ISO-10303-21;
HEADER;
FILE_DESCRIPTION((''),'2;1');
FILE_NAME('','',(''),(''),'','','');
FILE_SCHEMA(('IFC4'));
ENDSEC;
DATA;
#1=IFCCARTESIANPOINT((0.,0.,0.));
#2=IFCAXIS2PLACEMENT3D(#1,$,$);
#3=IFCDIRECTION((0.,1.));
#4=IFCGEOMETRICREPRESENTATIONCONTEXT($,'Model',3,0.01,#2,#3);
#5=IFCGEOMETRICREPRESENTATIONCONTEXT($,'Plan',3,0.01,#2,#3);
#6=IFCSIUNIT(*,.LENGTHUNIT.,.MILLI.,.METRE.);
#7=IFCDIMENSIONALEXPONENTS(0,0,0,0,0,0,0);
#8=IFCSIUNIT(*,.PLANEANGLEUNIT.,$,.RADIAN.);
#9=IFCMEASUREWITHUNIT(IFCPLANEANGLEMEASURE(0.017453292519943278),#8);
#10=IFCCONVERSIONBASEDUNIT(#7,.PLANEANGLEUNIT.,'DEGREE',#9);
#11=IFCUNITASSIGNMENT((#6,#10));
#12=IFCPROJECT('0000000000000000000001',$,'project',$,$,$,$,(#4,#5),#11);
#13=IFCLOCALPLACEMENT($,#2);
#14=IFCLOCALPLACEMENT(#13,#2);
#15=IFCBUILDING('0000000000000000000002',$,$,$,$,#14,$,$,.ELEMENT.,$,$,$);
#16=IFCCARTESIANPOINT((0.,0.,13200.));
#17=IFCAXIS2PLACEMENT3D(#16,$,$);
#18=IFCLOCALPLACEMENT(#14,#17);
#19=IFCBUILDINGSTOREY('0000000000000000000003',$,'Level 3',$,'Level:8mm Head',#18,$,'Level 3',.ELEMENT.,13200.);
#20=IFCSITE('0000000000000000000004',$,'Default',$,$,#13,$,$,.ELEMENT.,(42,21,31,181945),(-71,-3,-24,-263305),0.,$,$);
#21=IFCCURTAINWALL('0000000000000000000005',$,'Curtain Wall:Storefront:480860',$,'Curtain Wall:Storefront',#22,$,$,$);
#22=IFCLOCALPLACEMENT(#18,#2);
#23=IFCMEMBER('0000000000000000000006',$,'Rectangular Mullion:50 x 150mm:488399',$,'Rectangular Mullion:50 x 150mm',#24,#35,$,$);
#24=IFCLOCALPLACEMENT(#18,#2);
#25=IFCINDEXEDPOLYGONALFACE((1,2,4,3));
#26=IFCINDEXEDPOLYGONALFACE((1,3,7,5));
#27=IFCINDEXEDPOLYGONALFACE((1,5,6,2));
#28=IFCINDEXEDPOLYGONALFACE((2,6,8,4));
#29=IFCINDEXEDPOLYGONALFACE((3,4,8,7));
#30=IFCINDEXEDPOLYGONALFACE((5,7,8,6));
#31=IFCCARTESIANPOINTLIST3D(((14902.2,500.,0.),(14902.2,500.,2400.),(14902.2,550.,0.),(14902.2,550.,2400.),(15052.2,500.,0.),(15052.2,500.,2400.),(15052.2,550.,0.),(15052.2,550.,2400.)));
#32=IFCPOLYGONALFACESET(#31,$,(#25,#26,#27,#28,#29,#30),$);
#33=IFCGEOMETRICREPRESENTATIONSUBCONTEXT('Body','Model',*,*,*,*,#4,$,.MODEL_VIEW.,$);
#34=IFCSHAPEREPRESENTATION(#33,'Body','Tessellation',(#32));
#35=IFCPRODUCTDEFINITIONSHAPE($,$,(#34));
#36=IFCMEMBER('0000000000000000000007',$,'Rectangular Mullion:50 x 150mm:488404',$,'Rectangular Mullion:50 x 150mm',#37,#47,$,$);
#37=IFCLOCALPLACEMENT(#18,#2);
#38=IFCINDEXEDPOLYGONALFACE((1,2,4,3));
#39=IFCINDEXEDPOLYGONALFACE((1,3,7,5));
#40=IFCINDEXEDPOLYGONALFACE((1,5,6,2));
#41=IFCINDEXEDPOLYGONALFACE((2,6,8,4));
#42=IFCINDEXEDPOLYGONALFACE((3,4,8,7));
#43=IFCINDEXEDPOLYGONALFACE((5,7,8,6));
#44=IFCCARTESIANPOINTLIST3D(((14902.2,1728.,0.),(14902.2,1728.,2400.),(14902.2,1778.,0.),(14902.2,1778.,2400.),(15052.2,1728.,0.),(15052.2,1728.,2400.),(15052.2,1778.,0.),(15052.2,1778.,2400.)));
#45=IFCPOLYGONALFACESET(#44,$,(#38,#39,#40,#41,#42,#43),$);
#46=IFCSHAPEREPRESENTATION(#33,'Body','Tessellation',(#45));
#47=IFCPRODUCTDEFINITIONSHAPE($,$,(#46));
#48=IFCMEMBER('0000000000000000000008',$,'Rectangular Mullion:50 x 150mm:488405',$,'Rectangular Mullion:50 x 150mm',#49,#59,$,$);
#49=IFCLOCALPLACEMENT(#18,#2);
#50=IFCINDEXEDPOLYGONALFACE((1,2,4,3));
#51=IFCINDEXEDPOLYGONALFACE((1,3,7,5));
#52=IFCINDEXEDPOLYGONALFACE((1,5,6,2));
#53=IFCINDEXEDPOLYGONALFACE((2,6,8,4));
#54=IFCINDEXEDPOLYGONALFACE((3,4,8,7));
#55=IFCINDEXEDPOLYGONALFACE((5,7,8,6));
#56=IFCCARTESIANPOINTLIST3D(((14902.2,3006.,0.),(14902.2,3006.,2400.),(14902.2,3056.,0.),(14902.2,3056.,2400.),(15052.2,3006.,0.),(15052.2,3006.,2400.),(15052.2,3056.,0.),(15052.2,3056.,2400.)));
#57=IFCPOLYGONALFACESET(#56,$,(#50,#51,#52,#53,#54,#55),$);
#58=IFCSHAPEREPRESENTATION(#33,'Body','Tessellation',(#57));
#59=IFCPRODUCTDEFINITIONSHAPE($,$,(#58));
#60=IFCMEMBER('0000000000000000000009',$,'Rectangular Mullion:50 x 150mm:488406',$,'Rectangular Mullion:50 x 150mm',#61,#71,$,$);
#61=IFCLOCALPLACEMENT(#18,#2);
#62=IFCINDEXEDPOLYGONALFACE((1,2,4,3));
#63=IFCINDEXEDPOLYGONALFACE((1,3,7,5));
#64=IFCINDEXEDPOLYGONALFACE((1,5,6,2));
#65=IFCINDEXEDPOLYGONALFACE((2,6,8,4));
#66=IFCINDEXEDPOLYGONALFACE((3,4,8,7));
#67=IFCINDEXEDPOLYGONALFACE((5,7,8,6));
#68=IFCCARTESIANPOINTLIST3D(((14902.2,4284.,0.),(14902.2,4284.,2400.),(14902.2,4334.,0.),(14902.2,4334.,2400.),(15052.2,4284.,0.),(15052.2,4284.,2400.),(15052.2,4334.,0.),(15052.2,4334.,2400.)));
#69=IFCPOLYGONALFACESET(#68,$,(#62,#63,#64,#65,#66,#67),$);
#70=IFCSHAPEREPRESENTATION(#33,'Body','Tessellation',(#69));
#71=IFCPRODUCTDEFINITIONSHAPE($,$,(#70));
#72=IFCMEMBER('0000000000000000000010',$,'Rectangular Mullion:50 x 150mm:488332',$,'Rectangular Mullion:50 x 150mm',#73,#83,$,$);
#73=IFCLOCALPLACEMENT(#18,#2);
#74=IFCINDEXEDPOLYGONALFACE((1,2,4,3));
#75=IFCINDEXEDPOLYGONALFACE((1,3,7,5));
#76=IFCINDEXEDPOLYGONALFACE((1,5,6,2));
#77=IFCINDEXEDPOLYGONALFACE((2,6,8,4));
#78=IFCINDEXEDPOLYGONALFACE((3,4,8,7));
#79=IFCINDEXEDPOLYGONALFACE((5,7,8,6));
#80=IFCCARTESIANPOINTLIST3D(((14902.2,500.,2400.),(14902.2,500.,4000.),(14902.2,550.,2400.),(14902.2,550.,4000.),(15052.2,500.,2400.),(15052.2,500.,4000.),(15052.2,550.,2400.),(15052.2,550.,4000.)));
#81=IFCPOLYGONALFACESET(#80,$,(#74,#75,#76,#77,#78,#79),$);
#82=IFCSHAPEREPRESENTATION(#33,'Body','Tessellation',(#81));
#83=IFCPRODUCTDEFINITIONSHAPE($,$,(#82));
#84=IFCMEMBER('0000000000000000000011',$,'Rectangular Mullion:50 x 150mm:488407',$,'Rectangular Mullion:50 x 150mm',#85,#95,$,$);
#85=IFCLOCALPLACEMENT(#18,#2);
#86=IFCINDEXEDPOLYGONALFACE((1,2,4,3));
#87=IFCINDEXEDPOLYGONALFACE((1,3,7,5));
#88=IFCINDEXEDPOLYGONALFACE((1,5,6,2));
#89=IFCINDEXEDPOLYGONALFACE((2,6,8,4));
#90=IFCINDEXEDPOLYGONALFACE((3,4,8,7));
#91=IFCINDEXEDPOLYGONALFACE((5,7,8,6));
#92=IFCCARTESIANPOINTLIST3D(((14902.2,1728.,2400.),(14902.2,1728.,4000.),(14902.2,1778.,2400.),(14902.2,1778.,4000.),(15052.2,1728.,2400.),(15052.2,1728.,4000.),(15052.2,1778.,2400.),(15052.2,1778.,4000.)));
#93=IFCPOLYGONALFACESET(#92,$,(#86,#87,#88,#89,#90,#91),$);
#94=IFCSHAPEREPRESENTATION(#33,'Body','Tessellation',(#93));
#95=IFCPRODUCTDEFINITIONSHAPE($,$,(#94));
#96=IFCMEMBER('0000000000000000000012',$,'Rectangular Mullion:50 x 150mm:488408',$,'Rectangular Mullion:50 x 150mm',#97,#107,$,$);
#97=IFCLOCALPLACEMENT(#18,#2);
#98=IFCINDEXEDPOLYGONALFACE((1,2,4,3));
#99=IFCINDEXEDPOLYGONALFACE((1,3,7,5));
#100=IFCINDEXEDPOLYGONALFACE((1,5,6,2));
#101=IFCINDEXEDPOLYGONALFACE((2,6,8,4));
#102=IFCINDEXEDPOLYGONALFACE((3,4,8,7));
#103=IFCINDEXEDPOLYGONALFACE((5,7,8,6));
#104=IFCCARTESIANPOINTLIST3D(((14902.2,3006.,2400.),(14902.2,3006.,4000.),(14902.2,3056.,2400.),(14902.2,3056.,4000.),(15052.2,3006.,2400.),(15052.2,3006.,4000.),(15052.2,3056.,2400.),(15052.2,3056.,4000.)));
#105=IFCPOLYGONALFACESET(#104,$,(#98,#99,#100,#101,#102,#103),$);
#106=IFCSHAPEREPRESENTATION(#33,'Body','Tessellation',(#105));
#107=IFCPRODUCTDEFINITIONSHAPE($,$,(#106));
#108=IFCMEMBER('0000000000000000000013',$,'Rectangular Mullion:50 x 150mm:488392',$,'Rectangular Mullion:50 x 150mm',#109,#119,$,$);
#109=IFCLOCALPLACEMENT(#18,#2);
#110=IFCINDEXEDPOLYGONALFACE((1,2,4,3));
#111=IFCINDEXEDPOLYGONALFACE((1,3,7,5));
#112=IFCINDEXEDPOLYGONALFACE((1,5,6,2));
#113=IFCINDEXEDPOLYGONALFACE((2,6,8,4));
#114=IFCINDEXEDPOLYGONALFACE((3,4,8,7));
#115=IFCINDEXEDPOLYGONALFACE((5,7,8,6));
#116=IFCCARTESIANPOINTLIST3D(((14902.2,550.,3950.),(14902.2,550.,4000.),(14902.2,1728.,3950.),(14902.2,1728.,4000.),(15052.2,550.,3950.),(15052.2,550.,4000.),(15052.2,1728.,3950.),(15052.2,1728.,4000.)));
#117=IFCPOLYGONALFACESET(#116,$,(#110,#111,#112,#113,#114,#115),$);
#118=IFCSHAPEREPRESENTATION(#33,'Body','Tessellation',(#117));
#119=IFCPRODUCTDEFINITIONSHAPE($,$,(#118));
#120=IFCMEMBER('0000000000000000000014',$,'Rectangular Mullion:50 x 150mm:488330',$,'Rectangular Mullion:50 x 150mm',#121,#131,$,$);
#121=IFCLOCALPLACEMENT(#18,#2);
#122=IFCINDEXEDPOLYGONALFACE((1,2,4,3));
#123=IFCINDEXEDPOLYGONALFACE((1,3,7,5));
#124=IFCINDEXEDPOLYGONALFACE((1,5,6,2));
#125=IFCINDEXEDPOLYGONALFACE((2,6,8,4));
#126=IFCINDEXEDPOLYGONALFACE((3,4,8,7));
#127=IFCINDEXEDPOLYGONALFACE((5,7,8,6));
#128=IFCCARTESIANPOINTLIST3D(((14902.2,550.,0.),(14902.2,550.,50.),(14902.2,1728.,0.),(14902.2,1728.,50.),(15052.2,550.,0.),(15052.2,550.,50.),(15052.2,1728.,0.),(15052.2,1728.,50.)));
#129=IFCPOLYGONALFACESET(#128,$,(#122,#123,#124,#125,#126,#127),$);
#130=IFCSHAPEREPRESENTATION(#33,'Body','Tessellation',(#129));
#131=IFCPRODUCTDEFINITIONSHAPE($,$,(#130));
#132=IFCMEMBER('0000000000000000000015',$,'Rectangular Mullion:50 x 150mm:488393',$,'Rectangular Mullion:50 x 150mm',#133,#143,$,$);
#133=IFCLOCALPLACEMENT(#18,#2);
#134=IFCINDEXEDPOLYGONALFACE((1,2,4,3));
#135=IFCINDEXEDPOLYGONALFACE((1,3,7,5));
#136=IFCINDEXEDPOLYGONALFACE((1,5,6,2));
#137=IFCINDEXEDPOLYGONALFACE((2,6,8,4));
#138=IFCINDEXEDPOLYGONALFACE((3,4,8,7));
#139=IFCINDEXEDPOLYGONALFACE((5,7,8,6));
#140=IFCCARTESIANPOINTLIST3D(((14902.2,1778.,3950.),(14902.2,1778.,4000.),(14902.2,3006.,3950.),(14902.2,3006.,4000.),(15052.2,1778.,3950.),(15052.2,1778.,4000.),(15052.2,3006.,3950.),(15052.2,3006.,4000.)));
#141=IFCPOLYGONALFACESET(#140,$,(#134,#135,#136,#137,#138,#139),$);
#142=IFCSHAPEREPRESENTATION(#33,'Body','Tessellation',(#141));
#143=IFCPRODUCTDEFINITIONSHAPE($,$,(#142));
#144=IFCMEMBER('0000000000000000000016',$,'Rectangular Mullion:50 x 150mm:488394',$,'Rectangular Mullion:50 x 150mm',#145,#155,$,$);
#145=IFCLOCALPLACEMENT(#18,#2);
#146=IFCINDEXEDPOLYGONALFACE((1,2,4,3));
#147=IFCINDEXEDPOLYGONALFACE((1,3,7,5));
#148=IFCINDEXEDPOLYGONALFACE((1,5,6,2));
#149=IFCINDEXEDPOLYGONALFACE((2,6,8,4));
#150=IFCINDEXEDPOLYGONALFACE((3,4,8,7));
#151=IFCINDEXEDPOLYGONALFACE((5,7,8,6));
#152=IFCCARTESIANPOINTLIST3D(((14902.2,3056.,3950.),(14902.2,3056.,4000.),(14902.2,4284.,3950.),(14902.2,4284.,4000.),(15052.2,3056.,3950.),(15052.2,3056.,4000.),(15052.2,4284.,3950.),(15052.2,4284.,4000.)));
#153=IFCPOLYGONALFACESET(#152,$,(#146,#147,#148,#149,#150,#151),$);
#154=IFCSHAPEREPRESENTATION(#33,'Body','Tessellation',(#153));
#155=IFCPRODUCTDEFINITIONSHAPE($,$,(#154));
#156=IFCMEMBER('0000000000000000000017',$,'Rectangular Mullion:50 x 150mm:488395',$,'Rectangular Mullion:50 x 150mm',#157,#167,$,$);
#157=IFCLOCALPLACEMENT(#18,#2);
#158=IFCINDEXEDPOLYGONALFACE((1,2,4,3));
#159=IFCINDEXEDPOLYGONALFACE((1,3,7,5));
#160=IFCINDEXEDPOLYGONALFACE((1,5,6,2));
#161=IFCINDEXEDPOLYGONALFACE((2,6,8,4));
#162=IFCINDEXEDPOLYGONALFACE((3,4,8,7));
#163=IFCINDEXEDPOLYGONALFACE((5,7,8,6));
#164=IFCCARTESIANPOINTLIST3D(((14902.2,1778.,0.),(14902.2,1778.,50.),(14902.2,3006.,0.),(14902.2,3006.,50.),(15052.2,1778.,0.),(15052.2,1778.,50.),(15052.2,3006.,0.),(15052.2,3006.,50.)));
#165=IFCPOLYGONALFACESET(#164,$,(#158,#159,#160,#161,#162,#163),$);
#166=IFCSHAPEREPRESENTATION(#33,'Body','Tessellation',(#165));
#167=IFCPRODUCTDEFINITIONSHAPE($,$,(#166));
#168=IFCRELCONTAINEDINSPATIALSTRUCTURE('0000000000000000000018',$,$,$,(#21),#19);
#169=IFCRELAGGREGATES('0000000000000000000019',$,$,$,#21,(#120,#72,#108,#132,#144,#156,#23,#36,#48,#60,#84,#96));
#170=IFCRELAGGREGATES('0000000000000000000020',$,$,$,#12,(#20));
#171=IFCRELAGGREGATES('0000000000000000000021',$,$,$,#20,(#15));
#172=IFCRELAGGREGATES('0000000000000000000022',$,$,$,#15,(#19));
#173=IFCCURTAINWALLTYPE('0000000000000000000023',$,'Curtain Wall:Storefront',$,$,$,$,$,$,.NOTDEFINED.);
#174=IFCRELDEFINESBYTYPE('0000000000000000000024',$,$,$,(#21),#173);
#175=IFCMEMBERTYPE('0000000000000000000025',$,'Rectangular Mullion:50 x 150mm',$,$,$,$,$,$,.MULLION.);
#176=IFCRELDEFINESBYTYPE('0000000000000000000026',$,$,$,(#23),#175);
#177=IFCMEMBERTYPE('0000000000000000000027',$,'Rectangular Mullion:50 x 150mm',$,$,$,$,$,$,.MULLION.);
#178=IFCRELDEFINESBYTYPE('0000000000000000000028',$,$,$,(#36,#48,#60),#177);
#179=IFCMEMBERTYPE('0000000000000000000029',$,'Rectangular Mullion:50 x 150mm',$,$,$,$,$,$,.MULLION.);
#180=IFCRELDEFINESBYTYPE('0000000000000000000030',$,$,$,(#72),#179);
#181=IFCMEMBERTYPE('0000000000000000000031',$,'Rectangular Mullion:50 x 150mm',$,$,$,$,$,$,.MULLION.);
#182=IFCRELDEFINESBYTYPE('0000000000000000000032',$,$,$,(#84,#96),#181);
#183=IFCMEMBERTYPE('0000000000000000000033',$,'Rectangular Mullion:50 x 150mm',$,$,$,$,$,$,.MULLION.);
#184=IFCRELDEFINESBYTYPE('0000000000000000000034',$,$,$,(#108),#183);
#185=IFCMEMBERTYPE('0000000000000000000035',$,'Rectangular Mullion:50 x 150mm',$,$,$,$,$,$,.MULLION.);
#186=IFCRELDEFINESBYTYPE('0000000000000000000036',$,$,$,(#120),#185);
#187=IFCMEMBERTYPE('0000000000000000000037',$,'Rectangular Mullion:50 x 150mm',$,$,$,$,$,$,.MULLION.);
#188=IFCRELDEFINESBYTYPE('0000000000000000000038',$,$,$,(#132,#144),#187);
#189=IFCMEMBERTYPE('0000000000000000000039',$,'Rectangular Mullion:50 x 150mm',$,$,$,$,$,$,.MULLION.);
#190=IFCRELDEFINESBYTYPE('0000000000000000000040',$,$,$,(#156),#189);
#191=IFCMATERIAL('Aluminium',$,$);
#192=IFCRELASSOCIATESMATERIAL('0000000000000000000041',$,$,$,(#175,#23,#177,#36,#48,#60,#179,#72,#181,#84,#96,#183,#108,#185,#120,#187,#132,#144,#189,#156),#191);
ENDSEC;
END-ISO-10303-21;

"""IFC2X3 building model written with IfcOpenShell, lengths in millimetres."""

from ifc_helpers import new_model, entity, si_unit, converted_unit, direction, frame, origin, origin_2d_with_axis, place, context, subcontext, project, spatial, rectangle, extrude, source, transform, mapped, material, type_object, type_shapes, element, aggregate, save


model = new_model("IFC2X3")

# Units and contexts
model_context = context("Model", 3, precision=0.01, world=origin(), true_north=direction((0.0, 1.0)))
plan_context = context("Plan", 3, precision=0.01, world=origin(), true_north=direction((0.0, 1.0)))
body_context = subcontext(model_context, "Body", "Model", "MODEL_VIEW")
ifc_project = project(units=[si_unit("LENGTHUNIT", "METRE", prefix="MILLI"), converted_unit("PLANEANGLEUNIT", "DEGREE", entity("IfcPlaneAngleMeasure", 0.017453292519943278), si_unit("PLANEANGLEUNIT", "RADIAN"), dimensions=[0, 0, 0, 0, 0, 0, 0])], contexts=[model_context, plan_context])

# Site, building, storey
site_placement = place(None, origin())
site = spatial("IfcSite", under=ifc_project, at=site_placement, Name="Default", CompositionType="ELEMENT", RefLatitude=(42, 21, 31, 181945), RefLongitude=(-71, -3, -24, -263305), RefElevation=0.0)
building_placement = place(site_placement, origin())
building = spatial("IfcBuilding", under=site, at=building_placement, CompositionType="ELEMENT")
storey_placement = place(building_placement, frame((0.0, 0.0, 13200.0)))
storey = spatial("IfcBuildingStorey", under=building, at=storey_placement, Name="Level 3", ObjectType="Level:8mm Head", LongName="Level 3", CompositionType="ELEMENT", Elevation=13200.0)

# Curtain wall, members
curtain_wall_type = type_object("IfcCurtainWallType", Name="Curtain Wall:Storefront", PredefinedType="NOTDEFINED")
curtain_wall_placement = place(storey_placement, frame((0.0, 0.0, -13200.0)))
curtain_wall = element("IfcCurtainWall", 1, at=curtain_wall_placement, inside=storey, type_object=curtain_wall_type, Name="Curtain Wall:Storefront:480860", ObjectType="Curtain Wall:Storefront")
ifc_material_1 = material(Name="Aluminium")
member_type_1 = type_object("IfcMemberType", Name="Rectangular Mullion:50 x 150mm", PredefinedType="MULLION", material=ifc_material_1)
shared_shape_1 = source(origin(), body_context, "Body", "SweptSolid", [
    extrude(rectangle(XDim=50.0, YDim=150.0, at=origin_2d_with_axis()), frame((-25.0, 0.0, -2400.0), z_axis=(0.0, 0.0, 1.0), x_axis=(-1.0, 0.0, 0.0)), (0.0, 0.0, 1.0), 2400.0),
])
type_shapes(member_type_1, [shared_shape_1])
member_1_placement = place(curtain_wall_placement, frame((14977.2, 500.0, 15600.0), z_axis=(0.0, 0.0, 1.0), x_axis=(0.0, -1.0, 0.0)))
member_1 = element("IfcMember", 2, at=member_1_placement, type_object=member_type_1, material=ifc_material_1, Name="Rectangular Mullion:50 x 150mm:488399", ObjectType="Rectangular Mullion:50 x 150mm", context=body_context, shape_type="MappedRepresentation", body=[
    mapped(shared_shape_1, transform((0.0, 0.0, 0.0), scale=1.0)),
])
member_type_2 = type_object("IfcMemberType", Name="Rectangular Mullion:50 x 150mm", PredefinedType="MULLION", material=ifc_material_1)
shared_shape_2 = source(origin(), body_context, "Body", "SweptSolid", [
    extrude(rectangle(XDim=50.0, YDim=150.0, at=origin_2d_with_axis()), frame((0.0, 0.0, -2400.0), z_axis=(0.0, 0.0, 1.0), x_axis=(-1.0, 0.0, 0.0)), (0.0, 0.0, 1.0), 2400.0),
])
type_shapes(member_type_2, [shared_shape_2])
member_2_placement = place(curtain_wall_placement, frame((14977.2, 1753.0, 13200.0), z_axis=(0.0, 0.0, -1.0), x_axis=(0.0, 1.0, 0.0)))
member_2 = element("IfcMember", 3, at=member_2_placement, type_object=member_type_2, material=ifc_material_1, Name="Rectangular Mullion:50 x 150mm:488404", ObjectType="Rectangular Mullion:50 x 150mm", context=body_context, shape_type="MappedRepresentation", body=[
    mapped(shared_shape_2, transform((0.0, 0.0, 0.0), scale=1.0)),
])
member_3_placement = place(curtain_wall_placement, frame((14977.2, 3031.0, 13200.0), z_axis=(0.0, 0.0, -1.0), x_axis=(0.0, 1.0, 0.0)))
member_3 = element("IfcMember", 4, at=member_3_placement, type_object=member_type_2, material=ifc_material_1, Name="Rectangular Mullion:50 x 150mm:488405", ObjectType="Rectangular Mullion:50 x 150mm", context=body_context, shape_type="MappedRepresentation", body=[
    mapped(shared_shape_2, transform((0.0, 0.0, 0.0), scale=1.0)),
])
member_4_placement = place(curtain_wall_placement, frame((14977.2, 4309.0, 13200.0), z_axis=(0.0, 0.0, -1.0), x_axis=(0.0, 1.0, 0.0)))
member_4 = element("IfcMember", 5, at=member_4_placement, type_object=member_type_2, material=ifc_material_1, Name="Rectangular Mullion:50 x 150mm:488406", ObjectType="Rectangular Mullion:50 x 150mm", context=body_context, shape_type="MappedRepresentation", body=[
    mapped(shared_shape_2, transform((0.0, 0.0, 0.0), scale=1.0)),
])
member_type_3 = type_object("IfcMemberType", Name="Rectangular Mullion:50 x 150mm", PredefinedType="MULLION", material=ifc_material_1)
shared_shape_3 = source(origin(), body_context, "Body", "SweptSolid", [
    extrude(rectangle(XDim=50.0, YDim=150.0, at=origin_2d_with_axis()), frame((-25.0, 0.0, -1600.0), z_axis=(0.0, 0.0, 1.0), x_axis=(-1.0, 0.0, 0.0)), (0.0, 0.0, 1.0), 1600.0),
])
type_shapes(member_type_3, [shared_shape_3])
member_5_placement = place(curtain_wall_placement, frame((14977.2, 500.0, 17200.0), z_axis=(0.0, 0.0, 1.0), x_axis=(0.0, -1.0, 0.0)))
member_5 = element("IfcMember", 6, at=member_5_placement, type_object=member_type_3, material=ifc_material_1, Name="Rectangular Mullion:50 x 150mm:488332", ObjectType="Rectangular Mullion:50 x 150mm", context=body_context, shape_type="MappedRepresentation", body=[
    mapped(shared_shape_3, transform((0.0, 0.0, 0.0), scale=1.0)),
])
member_type_4 = type_object("IfcMemberType", Name="Rectangular Mullion:50 x 150mm", PredefinedType="MULLION", material=ifc_material_1)
shared_shape_4 = source(origin(), body_context, "Body", "SweptSolid", [
    extrude(rectangle(XDim=50.0, YDim=150.0, at=origin_2d_with_axis()), frame((0.0, 0.0, -1600.0), z_axis=(0.0, 0.0, 1.0), x_axis=(-1.0, 0.0, 0.0)), (0.0, 0.0, 1.0), 1600.0),
])
type_shapes(member_type_4, [shared_shape_4])
member_6_placement = place(curtain_wall_placement, frame((14977.2, 1753.0, 15600.0), z_axis=(0.0, 0.0, -1.0), x_axis=(0.0, 1.0, 0.0)))
member_6 = element("IfcMember", 7, at=member_6_placement, type_object=member_type_4, material=ifc_material_1, Name="Rectangular Mullion:50 x 150mm:488407", ObjectType="Rectangular Mullion:50 x 150mm", context=body_context, shape_type="MappedRepresentation", body=[
    mapped(shared_shape_4, transform((0.0, 0.0, 0.0), scale=1.0)),
])
member_7_placement = place(curtain_wall_placement, frame((14977.2, 3031.0, 15600.0), z_axis=(0.0, 0.0, -1.0), x_axis=(0.0, 1.0, 0.0)))
member_7 = element("IfcMember", 8, at=member_7_placement, type_object=member_type_4, material=ifc_material_1, Name="Rectangular Mullion:50 x 150mm:488408", ObjectType="Rectangular Mullion:50 x 150mm", context=body_context, shape_type="MappedRepresentation", body=[
    mapped(shared_shape_4, transform((0.0, 0.0, 0.0), scale=1.0)),
])
member_type_5 = type_object("IfcMemberType", Name="Rectangular Mullion:50 x 150mm", PredefinedType="MULLION", material=ifc_material_1)
shared_shape_5 = source(origin(), body_context, "Body", "SweptSolid", [
    extrude(rectangle(XDim=50.0, YDim=150.0, at=origin_2d_with_axis()), frame((-25.0, 0.0, -1178.0), z_axis=(0.0, 0.0, 1.0), x_axis=(-1.0, 0.0, 0.0)), (0.0, 0.0, 1.0), 1178.0),
])
type_shapes(member_type_5, [shared_shape_5])
member_8_placement = place(curtain_wall_placement, frame((14977.2, 1728.0, 17200.0), z_axis=(0.0, 1.0, 0.0), x_axis=(0.0, 0.0, 1.0)))
member_8 = element("IfcMember", 9, at=member_8_placement, type_object=member_type_5, material=ifc_material_1, Name="Rectangular Mullion:50 x 150mm:488392", ObjectType="Rectangular Mullion:50 x 150mm", context=body_context, shape_type="MappedRepresentation", body=[
    mapped(shared_shape_5, transform((0.0, 0.0, 0.0), scale=1.0)),
])
member_type_6 = type_object("IfcMemberType", Name="Rectangular Mullion:50 x 150mm", PredefinedType="MULLION", material=ifc_material_1)
shared_shape_6 = source(origin(), body_context, "Body", "SweptSolid", [
    extrude(rectangle(XDim=50.0, YDim=150.0, at=origin_2d_with_axis()), frame((-25.0, 0.0, -1178.0), z_axis=(0.0, 0.0, 1.0), x_axis=(-1.0, 0.0, 0.0)), (0.0, 0.0, 1.0), 1178.0),
])
type_shapes(member_type_6, [shared_shape_6])
member_9_placement = place(curtain_wall_placement, frame((14977.2, 550.0, 13200.0), z_axis=(0.0, -1.0, 0.0), x_axis=(0.0, 0.0, -1.0)))
member_9 = element("IfcMember", 10, at=member_9_placement, type_object=member_type_6, material=ifc_material_1, Name="Rectangular Mullion:50 x 150mm:488330", ObjectType="Rectangular Mullion:50 x 150mm", context=body_context, shape_type="MappedRepresentation", body=[
    mapped(shared_shape_6, transform((0.0, 0.0, 0.0), scale=1.0)),
])
member_type_7 = type_object("IfcMemberType", Name="Rectangular Mullion:50 x 150mm", PredefinedType="MULLION", material=ifc_material_1)
shared_shape_7 = source(origin(), body_context, "Body", "SweptSolid", [
    extrude(rectangle(XDim=50.0, YDim=150.0, at=origin_2d_with_axis()), frame((-25.0, 0.0, -1228.0), z_axis=(0.0, 0.0, 1.0), x_axis=(-1.0, 0.0, 0.0)), (0.0, 0.0, 1.0), 1228.0),
])
type_shapes(member_type_7, [shared_shape_7])
member_10_placement = place(curtain_wall_placement, frame((14977.2, 3006.0, 17200.0), z_axis=(0.0, 1.0, 0.0), x_axis=(0.0, 0.0, 1.0)))
member_10 = element("IfcMember", 11, at=member_10_placement, type_object=member_type_7, material=ifc_material_1, Name="Rectangular Mullion:50 x 150mm:488393", ObjectType="Rectangular Mullion:50 x 150mm", context=body_context, shape_type="MappedRepresentation", body=[
    mapped(shared_shape_7, transform((0.0, 0.0, 0.0), scale=1.0)),
])
member_11_placement = place(curtain_wall_placement, frame((14977.2, 4284.0, 17200.0), z_axis=(0.0, 1.0, 0.0), x_axis=(0.0, 0.0, 1.0)))
member_11 = element("IfcMember", 12, at=member_11_placement, type_object=member_type_7, material=ifc_material_1, Name="Rectangular Mullion:50 x 150mm:488394", ObjectType="Rectangular Mullion:50 x 150mm", context=body_context, shape_type="MappedRepresentation", body=[
    mapped(shared_shape_7, transform((0.0, 0.0, 0.0), scale=1.0)),
])
member_type_8 = type_object("IfcMemberType", Name="Rectangular Mullion:50 x 150mm", PredefinedType="MULLION", material=ifc_material_1)
shared_shape_8 = source(origin(), body_context, "Body", "SweptSolid", [
    extrude(rectangle(XDim=50.0, YDim=150.0, at=origin_2d_with_axis()), frame((-25.0, 0.0, -1228.0), z_axis=(0.0, 0.0, 1.0), x_axis=(-1.0, 0.0, 0.0)), (0.0, 0.0, 1.0), 1228.0),
])
type_shapes(member_type_8, [shared_shape_8])
member_12_placement = place(curtain_wall_placement, frame((14977.2, 1778.0, 13200.0), z_axis=(0.0, -1.0, 0.0), x_axis=(0.0, 0.0, -1.0)))
member_12 = element("IfcMember", 13, at=member_12_placement, type_object=member_type_8, material=ifc_material_1, Name="Rectangular Mullion:50 x 150mm:488395", ObjectType="Rectangular Mullion:50 x 150mm", context=body_context, shape_type="MappedRepresentation", body=[
    mapped(shared_shape_8, transform((0.0, 0.0, 0.0), scale=1.0)),
])

aggregate(curtain_wall, [member_9, member_5, member_8, member_10, member_11, member_12, member_1, member_2, member_3, member_4, member_6, member_7])

save(model, "model.ifc")
